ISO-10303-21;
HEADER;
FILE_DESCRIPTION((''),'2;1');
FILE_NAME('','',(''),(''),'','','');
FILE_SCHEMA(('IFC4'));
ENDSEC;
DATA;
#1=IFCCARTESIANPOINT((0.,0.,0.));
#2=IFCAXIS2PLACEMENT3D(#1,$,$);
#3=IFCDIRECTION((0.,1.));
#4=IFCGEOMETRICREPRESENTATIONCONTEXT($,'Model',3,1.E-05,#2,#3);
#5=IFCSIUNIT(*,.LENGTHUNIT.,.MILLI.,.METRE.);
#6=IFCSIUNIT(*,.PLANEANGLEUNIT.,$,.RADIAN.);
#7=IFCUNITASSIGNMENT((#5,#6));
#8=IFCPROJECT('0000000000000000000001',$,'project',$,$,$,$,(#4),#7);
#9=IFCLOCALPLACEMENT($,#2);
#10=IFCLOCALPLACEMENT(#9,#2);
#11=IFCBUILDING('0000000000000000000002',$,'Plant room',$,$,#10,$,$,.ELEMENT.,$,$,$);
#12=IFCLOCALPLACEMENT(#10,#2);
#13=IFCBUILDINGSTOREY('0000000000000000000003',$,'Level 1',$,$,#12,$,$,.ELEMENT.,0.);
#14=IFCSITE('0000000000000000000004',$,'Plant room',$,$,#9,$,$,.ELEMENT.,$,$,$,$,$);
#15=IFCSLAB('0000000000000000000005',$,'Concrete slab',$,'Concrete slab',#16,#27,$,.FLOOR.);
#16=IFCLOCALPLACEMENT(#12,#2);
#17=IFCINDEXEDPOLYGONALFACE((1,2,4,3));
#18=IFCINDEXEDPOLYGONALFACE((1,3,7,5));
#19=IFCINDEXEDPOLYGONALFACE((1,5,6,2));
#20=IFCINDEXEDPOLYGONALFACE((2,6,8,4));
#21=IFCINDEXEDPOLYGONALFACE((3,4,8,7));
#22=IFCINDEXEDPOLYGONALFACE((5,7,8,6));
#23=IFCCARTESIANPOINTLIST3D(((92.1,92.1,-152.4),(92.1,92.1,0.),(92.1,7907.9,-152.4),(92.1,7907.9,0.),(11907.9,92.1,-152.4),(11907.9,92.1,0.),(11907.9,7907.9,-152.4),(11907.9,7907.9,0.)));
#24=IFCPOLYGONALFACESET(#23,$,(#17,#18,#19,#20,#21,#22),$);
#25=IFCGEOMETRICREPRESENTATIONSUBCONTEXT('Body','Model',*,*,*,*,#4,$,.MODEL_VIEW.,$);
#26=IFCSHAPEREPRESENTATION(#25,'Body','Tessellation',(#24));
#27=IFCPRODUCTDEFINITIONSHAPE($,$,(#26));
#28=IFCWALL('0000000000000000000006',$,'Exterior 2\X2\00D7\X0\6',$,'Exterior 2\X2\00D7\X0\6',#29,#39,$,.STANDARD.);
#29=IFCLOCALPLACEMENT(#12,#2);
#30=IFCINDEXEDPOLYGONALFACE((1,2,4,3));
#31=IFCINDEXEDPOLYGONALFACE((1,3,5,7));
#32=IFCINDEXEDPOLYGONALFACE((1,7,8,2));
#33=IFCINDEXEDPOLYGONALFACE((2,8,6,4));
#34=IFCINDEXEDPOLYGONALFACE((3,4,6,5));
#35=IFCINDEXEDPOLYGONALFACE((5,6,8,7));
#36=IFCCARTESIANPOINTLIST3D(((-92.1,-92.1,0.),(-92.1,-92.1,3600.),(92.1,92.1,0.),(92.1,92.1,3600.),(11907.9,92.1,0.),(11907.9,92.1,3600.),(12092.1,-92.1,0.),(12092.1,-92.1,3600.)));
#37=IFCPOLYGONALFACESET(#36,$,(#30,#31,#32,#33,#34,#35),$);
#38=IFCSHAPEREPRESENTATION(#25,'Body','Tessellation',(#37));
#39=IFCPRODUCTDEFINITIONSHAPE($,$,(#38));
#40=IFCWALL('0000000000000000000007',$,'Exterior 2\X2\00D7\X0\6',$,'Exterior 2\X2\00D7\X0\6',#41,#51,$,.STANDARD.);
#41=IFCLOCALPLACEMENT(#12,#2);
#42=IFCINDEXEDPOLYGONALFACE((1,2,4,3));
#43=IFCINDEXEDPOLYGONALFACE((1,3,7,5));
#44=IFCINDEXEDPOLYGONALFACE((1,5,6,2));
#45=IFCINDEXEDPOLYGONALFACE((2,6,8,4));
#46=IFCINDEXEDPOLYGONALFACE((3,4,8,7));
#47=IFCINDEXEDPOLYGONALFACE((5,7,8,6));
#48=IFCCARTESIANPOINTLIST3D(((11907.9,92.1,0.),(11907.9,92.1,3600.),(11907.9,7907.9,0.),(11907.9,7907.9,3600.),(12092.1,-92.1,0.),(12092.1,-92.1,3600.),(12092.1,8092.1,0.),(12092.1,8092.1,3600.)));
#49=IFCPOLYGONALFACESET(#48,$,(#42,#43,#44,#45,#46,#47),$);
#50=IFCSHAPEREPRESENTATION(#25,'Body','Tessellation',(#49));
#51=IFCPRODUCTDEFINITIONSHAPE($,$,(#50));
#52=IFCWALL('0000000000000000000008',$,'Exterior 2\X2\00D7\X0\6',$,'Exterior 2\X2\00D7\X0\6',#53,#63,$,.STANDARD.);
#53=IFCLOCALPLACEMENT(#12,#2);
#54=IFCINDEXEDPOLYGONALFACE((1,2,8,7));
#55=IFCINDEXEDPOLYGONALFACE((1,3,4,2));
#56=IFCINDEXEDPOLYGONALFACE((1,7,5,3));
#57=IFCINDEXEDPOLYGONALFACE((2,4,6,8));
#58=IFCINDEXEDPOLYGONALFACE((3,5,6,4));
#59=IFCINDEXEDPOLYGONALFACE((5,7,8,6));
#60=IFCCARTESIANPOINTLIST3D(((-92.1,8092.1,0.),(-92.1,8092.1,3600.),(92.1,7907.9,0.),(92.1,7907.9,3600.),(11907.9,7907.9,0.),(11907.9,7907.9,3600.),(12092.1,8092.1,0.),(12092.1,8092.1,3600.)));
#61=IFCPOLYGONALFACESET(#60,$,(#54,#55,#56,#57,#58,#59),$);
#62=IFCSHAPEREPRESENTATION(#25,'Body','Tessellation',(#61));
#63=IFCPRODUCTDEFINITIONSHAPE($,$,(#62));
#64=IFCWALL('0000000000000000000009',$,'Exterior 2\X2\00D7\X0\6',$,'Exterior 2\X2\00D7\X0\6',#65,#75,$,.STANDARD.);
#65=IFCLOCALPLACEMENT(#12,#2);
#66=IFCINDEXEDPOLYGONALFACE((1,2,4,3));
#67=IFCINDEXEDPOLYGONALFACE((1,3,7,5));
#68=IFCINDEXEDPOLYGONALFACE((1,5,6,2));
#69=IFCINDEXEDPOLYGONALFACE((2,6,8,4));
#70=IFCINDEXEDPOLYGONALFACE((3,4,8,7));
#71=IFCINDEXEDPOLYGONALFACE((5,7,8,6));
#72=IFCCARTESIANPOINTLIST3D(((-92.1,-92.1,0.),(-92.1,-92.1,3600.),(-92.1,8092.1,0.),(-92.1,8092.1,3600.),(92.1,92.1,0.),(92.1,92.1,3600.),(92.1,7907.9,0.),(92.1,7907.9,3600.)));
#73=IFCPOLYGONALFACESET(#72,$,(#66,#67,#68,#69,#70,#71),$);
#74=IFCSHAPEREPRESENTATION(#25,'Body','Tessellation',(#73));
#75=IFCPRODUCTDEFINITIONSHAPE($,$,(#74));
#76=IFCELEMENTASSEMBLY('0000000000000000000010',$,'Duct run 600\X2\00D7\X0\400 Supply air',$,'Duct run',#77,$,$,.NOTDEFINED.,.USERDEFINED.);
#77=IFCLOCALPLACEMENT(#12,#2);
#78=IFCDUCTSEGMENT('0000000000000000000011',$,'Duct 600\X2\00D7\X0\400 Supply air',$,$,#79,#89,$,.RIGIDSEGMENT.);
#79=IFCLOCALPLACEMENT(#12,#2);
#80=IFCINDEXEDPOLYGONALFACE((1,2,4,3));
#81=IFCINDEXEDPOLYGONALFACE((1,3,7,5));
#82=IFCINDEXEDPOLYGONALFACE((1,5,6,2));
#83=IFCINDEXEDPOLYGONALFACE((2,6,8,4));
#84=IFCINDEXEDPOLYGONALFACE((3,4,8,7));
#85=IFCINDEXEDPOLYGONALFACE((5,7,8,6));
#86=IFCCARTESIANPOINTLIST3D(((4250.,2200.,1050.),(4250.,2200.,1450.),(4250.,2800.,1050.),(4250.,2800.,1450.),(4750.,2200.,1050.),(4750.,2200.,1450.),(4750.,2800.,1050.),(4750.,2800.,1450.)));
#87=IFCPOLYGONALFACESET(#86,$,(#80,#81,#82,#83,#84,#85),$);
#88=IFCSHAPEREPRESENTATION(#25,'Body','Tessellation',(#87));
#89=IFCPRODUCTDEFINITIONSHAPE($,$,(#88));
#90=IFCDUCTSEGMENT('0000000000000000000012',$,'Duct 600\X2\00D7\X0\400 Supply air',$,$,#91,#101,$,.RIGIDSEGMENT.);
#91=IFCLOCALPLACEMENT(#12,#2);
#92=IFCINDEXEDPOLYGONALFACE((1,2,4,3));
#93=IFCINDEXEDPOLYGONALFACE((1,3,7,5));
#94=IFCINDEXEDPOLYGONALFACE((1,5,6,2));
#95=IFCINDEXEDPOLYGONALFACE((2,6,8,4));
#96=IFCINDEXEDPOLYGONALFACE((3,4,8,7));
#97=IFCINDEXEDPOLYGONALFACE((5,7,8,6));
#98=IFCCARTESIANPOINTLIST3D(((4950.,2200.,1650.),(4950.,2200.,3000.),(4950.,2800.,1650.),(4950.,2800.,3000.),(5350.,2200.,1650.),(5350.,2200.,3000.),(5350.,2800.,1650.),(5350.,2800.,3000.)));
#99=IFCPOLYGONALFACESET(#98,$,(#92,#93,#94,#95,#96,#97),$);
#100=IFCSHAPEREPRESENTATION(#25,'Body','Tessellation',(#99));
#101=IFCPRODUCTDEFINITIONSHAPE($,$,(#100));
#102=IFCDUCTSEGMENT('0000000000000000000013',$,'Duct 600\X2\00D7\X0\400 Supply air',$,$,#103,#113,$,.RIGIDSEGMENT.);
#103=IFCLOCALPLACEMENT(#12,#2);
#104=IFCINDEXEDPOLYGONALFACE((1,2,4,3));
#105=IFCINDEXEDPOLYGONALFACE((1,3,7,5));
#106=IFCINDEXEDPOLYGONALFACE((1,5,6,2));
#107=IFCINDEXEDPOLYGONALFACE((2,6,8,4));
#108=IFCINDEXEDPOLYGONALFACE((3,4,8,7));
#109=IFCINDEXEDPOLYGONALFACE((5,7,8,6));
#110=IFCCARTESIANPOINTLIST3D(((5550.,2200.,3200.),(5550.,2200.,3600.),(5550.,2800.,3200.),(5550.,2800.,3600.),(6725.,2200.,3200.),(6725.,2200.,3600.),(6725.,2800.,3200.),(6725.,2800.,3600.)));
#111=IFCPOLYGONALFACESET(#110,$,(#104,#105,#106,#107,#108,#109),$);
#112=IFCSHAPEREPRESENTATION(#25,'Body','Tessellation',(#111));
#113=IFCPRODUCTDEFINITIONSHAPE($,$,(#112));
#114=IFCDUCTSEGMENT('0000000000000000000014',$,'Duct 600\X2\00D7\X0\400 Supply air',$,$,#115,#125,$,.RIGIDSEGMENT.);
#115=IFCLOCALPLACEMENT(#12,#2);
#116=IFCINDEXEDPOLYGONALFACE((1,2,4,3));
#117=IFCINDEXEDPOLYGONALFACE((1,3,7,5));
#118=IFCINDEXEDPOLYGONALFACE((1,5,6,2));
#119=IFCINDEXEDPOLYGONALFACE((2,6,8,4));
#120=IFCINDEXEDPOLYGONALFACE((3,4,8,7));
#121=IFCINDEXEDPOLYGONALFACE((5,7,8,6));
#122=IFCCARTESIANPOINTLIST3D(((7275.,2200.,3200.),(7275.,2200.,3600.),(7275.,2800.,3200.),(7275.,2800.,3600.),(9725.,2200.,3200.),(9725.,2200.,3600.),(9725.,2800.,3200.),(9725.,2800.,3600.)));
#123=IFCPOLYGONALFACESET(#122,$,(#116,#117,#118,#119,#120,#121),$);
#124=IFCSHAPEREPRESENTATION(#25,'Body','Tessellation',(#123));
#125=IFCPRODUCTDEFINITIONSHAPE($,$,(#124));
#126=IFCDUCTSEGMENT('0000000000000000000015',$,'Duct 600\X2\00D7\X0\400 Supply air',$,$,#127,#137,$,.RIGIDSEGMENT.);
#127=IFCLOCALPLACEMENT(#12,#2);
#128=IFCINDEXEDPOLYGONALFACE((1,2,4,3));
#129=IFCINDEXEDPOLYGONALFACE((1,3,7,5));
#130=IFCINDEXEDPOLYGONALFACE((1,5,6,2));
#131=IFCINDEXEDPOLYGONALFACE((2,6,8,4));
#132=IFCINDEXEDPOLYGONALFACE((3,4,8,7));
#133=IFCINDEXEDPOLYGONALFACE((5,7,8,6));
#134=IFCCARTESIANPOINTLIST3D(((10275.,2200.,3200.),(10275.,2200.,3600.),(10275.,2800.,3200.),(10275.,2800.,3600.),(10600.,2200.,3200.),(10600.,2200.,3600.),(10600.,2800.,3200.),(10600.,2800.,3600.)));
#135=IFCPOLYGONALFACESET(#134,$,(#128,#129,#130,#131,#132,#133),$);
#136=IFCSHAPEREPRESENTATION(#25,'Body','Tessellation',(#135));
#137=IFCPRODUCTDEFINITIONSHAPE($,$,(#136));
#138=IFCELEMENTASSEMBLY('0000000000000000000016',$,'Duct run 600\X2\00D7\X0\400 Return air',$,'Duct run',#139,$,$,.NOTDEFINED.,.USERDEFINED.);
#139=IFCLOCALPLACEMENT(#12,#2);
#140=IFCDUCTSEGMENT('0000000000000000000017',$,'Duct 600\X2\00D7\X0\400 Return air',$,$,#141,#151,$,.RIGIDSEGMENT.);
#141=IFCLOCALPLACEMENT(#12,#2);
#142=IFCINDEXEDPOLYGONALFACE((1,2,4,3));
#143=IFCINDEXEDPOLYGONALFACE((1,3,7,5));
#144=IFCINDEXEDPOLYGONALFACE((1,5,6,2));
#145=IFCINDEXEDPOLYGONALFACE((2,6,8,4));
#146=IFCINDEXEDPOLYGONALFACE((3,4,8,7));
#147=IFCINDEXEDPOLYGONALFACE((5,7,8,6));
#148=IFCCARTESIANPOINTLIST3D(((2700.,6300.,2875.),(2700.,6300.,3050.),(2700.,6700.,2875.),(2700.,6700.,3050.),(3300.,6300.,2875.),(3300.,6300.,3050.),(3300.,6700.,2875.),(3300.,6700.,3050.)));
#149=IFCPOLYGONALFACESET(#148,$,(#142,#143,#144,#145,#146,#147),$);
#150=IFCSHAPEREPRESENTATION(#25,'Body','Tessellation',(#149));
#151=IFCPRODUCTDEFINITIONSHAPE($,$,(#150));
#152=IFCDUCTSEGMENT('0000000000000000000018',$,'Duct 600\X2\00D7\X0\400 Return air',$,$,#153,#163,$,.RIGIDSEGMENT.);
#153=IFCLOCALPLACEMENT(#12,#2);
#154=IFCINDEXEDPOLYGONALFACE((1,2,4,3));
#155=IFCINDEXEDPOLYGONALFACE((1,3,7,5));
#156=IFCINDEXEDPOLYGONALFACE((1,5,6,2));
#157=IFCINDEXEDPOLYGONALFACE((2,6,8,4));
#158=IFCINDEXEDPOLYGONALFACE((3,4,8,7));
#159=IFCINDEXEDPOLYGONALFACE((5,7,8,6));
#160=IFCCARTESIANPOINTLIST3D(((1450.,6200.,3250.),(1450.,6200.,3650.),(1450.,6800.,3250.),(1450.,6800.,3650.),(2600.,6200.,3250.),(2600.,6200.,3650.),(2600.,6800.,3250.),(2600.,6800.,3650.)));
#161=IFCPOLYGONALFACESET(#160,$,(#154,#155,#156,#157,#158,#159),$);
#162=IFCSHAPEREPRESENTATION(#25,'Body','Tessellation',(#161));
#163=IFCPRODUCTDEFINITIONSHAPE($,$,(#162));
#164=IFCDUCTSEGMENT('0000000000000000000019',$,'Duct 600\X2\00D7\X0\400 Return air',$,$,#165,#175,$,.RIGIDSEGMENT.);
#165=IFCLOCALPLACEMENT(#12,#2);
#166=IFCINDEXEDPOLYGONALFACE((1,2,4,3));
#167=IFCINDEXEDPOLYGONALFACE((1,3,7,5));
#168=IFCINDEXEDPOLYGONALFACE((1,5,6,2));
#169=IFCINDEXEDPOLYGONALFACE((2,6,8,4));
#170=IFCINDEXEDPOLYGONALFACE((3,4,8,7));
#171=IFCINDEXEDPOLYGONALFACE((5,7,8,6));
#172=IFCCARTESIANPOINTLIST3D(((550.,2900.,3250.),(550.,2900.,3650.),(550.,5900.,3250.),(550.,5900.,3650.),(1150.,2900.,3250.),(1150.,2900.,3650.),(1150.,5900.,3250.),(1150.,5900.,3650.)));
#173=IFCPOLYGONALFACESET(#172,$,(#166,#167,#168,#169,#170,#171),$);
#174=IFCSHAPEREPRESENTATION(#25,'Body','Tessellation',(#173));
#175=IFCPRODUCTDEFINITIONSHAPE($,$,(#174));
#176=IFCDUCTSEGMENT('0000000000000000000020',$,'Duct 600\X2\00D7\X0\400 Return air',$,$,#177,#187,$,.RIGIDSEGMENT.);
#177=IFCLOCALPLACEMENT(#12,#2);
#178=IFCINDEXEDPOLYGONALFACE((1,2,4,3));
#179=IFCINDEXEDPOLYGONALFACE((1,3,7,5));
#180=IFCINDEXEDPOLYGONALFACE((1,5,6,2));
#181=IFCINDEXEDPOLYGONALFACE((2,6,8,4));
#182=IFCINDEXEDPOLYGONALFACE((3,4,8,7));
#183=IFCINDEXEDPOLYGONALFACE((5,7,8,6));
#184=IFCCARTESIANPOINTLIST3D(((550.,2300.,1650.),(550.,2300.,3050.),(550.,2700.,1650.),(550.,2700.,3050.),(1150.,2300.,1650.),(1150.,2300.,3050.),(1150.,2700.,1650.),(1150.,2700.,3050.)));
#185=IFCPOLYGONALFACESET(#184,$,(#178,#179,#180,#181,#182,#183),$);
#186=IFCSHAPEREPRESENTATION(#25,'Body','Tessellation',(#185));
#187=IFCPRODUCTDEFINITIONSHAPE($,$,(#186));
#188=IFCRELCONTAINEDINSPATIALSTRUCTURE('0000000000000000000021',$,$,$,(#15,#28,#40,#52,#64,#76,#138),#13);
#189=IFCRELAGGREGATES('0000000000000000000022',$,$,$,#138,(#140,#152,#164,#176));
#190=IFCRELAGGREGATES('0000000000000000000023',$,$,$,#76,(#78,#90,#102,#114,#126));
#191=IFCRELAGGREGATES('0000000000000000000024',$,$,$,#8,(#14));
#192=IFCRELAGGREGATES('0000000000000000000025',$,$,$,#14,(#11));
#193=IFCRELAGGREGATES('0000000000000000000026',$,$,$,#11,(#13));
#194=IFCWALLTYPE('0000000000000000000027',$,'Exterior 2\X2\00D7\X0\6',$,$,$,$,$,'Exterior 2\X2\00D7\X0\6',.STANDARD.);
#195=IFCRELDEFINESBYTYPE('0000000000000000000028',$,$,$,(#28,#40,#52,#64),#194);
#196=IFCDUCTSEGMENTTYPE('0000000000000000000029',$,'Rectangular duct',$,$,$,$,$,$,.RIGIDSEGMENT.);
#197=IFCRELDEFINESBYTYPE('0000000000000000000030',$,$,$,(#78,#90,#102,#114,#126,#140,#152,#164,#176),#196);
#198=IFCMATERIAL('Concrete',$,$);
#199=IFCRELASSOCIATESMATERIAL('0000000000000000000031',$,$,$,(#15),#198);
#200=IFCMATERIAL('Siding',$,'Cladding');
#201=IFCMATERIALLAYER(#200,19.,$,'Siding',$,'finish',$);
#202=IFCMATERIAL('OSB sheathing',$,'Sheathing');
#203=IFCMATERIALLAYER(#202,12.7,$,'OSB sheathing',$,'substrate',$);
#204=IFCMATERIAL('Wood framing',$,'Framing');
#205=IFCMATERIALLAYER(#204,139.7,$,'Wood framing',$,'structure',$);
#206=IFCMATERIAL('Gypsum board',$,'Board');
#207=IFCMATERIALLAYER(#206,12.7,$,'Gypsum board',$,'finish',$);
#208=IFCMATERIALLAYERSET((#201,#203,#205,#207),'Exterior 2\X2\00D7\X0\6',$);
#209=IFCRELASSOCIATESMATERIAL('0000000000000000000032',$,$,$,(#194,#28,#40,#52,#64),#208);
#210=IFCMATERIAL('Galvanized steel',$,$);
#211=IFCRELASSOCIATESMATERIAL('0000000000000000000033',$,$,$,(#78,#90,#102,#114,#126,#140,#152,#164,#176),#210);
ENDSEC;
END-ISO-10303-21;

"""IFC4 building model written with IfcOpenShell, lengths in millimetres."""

from ifc_helpers import new_model, si_unit, direction, frame, origin, origin_with_axes, origin_2d, place, context, subcontext, project, spatial, polyline, rectangle, outline, extrude, material, layer, layer_set, layer_usage, type_object, element, aggregate, save


model = new_model("IFC4")

# Units and contexts
model_context = context("Model", 3, precision=1e-05, world=origin(), true_north=direction((0.0, 1.0)))
body_context = subcontext(model_context, "Body", "Model", "MODEL_VIEW")
ifc_project = project(units=[si_unit("LENGTHUNIT", "METRE", prefix="MILLI"), si_unit("PLANEANGLEUNIT", "RADIAN")], contexts=[model_context])

# Site, building, storey
site_placement = place(None, origin())
site = spatial("IfcSite", under=ifc_project, at=site_placement, Name="Plant room", CompositionType="ELEMENT")
building_placement = place(site_placement, origin())
building = spatial("IfcBuilding", under=site, at=building_placement, Name="Plant room", CompositionType="ELEMENT")
storey_placement = place(building_placement, origin())
storey = spatial("IfcBuildingStorey", under=building, at=storey_placement, Name="Level 1", CompositionType="ELEMENT", Elevation=0.0)

# Slab
ifc_material_1 = material(Name="Concrete")
slab_placement = place(storey_placement, origin_with_axes())
element("IfcSlab", 1, at=slab_placement, inside=storey, material=ifc_material_1, Name="Concrete slab", ObjectType="Concrete slab", PredefinedType="FLOOR", context=body_context, shape_type="SweptSolid", body=[
    extrude(outline(polyline([(92.1, 92.1), (11907.9, 92.1), (11907.9, 7907.9), (92.1, 7907.9), (92.1, 92.1)])), frame((0.0, 0.0, -152.4)), (0.0, 0.0, 1.0), 152.4),
])

# Walls
ifc_material_2 = material(Name="Siding", Category="Cladding")
ifc_layer_1 = layer(ifc_material_2, 19.0, Name="Siding", Category="finish")
ifc_material_3 = material(Name="OSB sheathing", Category="Sheathing")
ifc_layer_2 = layer(ifc_material_3, 12.7, Name="OSB sheathing", Category="substrate")
ifc_material_4 = material(Name="Wood framing", Category="Framing")
ifc_layer_3 = layer(ifc_material_4, 139.7, Name="Wood framing", Category="structure")
ifc_material_5 = material(Name="Gypsum board", Category="Board")
ifc_layer_4 = layer(ifc_material_5, 12.7, Name="Gypsum board", Category="finish")
ifc_layer_set = layer_set([ifc_layer_1, ifc_layer_2, ifc_layer_3, ifc_layer_4], Name="Exterior 2×6")
ifc_layer_usage_1 = layer_usage(ifc_layer_set, "AXIS2", "NEGATIVE", 92.1)
wall_type = type_object("IfcWallType", Name="Exterior 2×6", ElementType="Exterior 2×6", PredefinedType="STANDARD", material=ifc_layer_set)
wall_1_placement = place(storey_placement, origin_with_axes())
element("IfcWall", 2, at=wall_1_placement, inside=storey, type_object=wall_type, material=ifc_layer_usage_1, Name="Exterior 2×6", ObjectType="Exterior 2×6", PredefinedType="STANDARD", context=body_context, shape_type="SweptSolid", body=[
    extrude(outline(polyline([(-92.1, -92.1), (12092.1, -92.1), (11907.9, 92.1), (92.1, 92.1), (-92.1, -92.1)])), origin(), (0.0, 0.0, 1.0), 3600.0),
])
ifc_layer_usage_2 = layer_usage(ifc_layer_set, "AXIS2", "NEGATIVE", 92.1)
wall_2_placement = place(storey_placement, frame((12000.0, 0.0, 0.0), z_axis=(0.0, 0.0, 1.0), x_axis=(0.0, 1.0, 0.0)))
element("IfcWall", 3, at=wall_2_placement, inside=storey, type_object=wall_type, material=ifc_layer_usage_2, Name="Exterior 2×6", ObjectType="Exterior 2×6", PredefinedType="STANDARD", context=body_context, shape_type="SweptSolid", body=[
    extrude(outline(polyline([(-92.1, -92.1), (8092.1, -92.1), (7907.9, 92.1), (92.1, 92.1), (-92.1, -92.1)])), origin(), (0.0, 0.0, 1.0), 3600.0),
])
ifc_layer_usage_3 = layer_usage(ifc_layer_set, "AXIS2", "NEGATIVE", 92.1)
wall_3_placement = place(storey_placement, frame((12000.0, 8000.0, 0.0), z_axis=(0.0, 0.0, 1.0), x_axis=(-1.0, 0.0, 0.0)))
element("IfcWall", 4, at=wall_3_placement, inside=storey, type_object=wall_type, material=ifc_layer_usage_3, Name="Exterior 2×6", ObjectType="Exterior 2×6", PredefinedType="STANDARD", context=body_context, shape_type="SweptSolid", body=[
    extrude(outline(polyline([(-92.1, -92.1), (12092.1, -92.1), (11907.9, 92.1), (92.1, 92.1), (-92.1, -92.1)])), origin(), (0.0, 0.0, 1.0), 3600.0),
])
ifc_layer_usage_4 = layer_usage(ifc_layer_set, "AXIS2", "NEGATIVE", 92.1)
wall_4_placement = place(storey_placement, frame((0.0, 8000.0, 0.0), z_axis=(0.0, 0.0, 1.0), x_axis=(0.0, -1.0, 0.0)))
element("IfcWall", 5, at=wall_4_placement, inside=storey, type_object=wall_type, material=ifc_layer_usage_4, Name="Exterior 2×6", ObjectType="Exterior 2×6", PredefinedType="STANDARD", context=body_context, shape_type="SweptSolid", body=[
    extrude(outline(polyline([(-92.1, -92.1), (8092.1, -92.1), (7907.9, 92.1), (92.1, 92.1), (-92.1, -92.1)])), origin(), (0.0, 0.0, 1.0), 3600.0),
])

# Element assemblies, duct segments
assembly_1_placement = place(storey_placement, origin_with_axes())
assembly_1 = element("IfcElementAssembly", 6, at=assembly_1_placement, inside=storey, Name="Duct run 600×400 Supply air", ObjectType="Duct run", AssemblyPlace="NOTDEFINED", PredefinedType="USERDEFINED")
ifc_material_6 = material(Name="Galvanized steel")
duct_segment_type_1 = type_object("IfcDuctSegmentType", Name="Rectangular duct", PredefinedType="RIGIDSEGMENT")
duct_segment_1_placement = place(storey_placement, origin_with_axes())
duct_segment_1 = element("IfcDuctSegment", 7, at=duct_segment_1_placement, type_object=duct_segment_type_1, material=ifc_material_6, Name="Duct 600×400 Supply air", PredefinedType="RIGIDSEGMENT", context=body_context, shape_type="SweptSolid", body=[
    extrude(rectangle(XDim=600.0, YDim=400.0, at=origin_2d()), frame((4250.0, 2500.0, 1250.0), z_axis=(1.0, 0.0, 0.0), x_axis=(0.0, 1.0, 0.0)), (0.0, 0.0, 1.0), 500.0),
])
duct_segment_2_placement = place(storey_placement, origin_with_axes())
duct_segment_2 = element("IfcDuctSegment", 8, at=duct_segment_2_placement, type_object=duct_segment_type_1, material=ifc_material_6, Name="Duct 600×400 Supply air", PredefinedType="RIGIDSEGMENT", context=body_context, shape_type="SweptSolid", body=[
    extrude(rectangle(XDim=600.0, YDim=400.0, at=origin_2d()), frame((5150.0, 2500.0, 1650.0), z_axis=(0.0, 0.0, 1.0), x_axis=(0.0, 1.0, 0.0)), (0.0, 0.0, 1.0), 1350.0),
])
duct_segment_3_placement = place(storey_placement, origin_with_axes())
duct_segment_3 = element("IfcDuctSegment", 9, at=duct_segment_3_placement, type_object=duct_segment_type_1, material=ifc_material_6, Name="Duct 600×400 Supply air", PredefinedType="RIGIDSEGMENT", context=body_context, shape_type="SweptSolid", body=[
    extrude(rectangle(XDim=600.0, YDim=400.0, at=origin_2d()), frame((5550.0, 2500.0, 3400.0), z_axis=(1.0, 0.0, 0.0), x_axis=(0.0, 1.0, 0.0)), (0.0, 0.0, 1.0), 1175.0),
])
duct_segment_4_placement = place(storey_placement, origin_with_axes())
duct_segment_4 = element("IfcDuctSegment", 10, at=duct_segment_4_placement, type_object=duct_segment_type_1, material=ifc_material_6, Name="Duct 600×400 Supply air", PredefinedType="RIGIDSEGMENT", context=body_context, shape_type="SweptSolid", body=[
    extrude(rectangle(XDim=600.0, YDim=400.0, at=origin_2d()), frame((7275.0, 2500.0, 3400.0), z_axis=(1.0, 0.0, 0.0), x_axis=(0.0, 1.0, 0.0)), (0.0, 0.0, 1.0), 2450.0),
])
duct_segment_5_placement = place(storey_placement, origin_with_axes())
duct_segment_5 = element("IfcDuctSegment", 11, at=duct_segment_5_placement, type_object=duct_segment_type_1, material=ifc_material_6, Name="Duct 600×400 Supply air", PredefinedType="RIGIDSEGMENT", context=body_context, shape_type="SweptSolid", body=[
    extrude(rectangle(XDim=600.0, YDim=400.0, at=origin_2d()), frame((10275.0, 2500.0, 3400.0), z_axis=(1.0, 0.0, 0.0), x_axis=(0.0, 1.0, 0.0)), (0.0, 0.0, 1.0), 325.0),
])
assembly_2_placement = place(storey_placement, origin_with_axes())
assembly_2 = element("IfcElementAssembly", 12, at=assembly_2_placement, inside=storey, Name="Duct run 600×400 Return air", ObjectType="Duct run", AssemblyPlace="NOTDEFINED", PredefinedType="USERDEFINED")
duct_segment_6_placement = place(storey_placement, origin_with_axes())
duct_segment_6 = element("IfcDuctSegment", 13, at=duct_segment_6_placement, type_object=duct_segment_type_1, material=ifc_material_6, Name="Duct 600×400 Return air", PredefinedType="RIGIDSEGMENT", context=body_context, shape_type="SweptSolid", body=[
    extrude(rectangle(XDim=600.0, YDim=400.0, at=origin_2d()), frame((3000.0, 6500.0, 2875.0), z_axis=(0.0, 0.0, 1.0), x_axis=(1.0, 0.0, 0.0)), (0.0, 0.0, 1.0), 175.0),
])
duct_segment_7_placement = place(storey_placement, origin_with_axes())
duct_segment_7 = element("IfcDuctSegment", 14, at=duct_segment_7_placement, type_object=duct_segment_type_1, material=ifc_material_6, Name="Duct 600×400 Return air", PredefinedType="RIGIDSEGMENT", context=body_context, shape_type="SweptSolid", body=[
    extrude(rectangle(XDim=600.0, YDim=400.0, at=origin_2d()), frame((2600.0, 6500.0, 3450.0), z_axis=(-1.0, 0.0, 0.0), x_axis=(0.0, -1.0, 0.0)), (0.0, 0.0, 1.0), 1150.0),
])
duct_segment_8_placement = place(storey_placement, origin_with_axes())
duct_segment_8 = element("IfcDuctSegment", 15, at=duct_segment_8_placement, type_object=duct_segment_type_1, material=ifc_material_6, Name="Duct 600×400 Return air", PredefinedType="RIGIDSEGMENT", context=body_context, shape_type="SweptSolid", body=[
    extrude(rectangle(XDim=600.0, YDim=400.0, at=origin_2d()), frame((850.0, 5900.0, 3450.0), z_axis=(0.0, -1.0, 0.0), x_axis=(1.0, 0.0, 0.0)), (0.0, 0.0, 1.0), 3000.0),
])
duct_segment_9_placement = place(storey_placement, origin_with_axes())
duct_segment_9 = element("IfcDuctSegment", 16, at=duct_segment_9_placement, type_object=duct_segment_type_1, material=ifc_material_6, Name="Duct 600×400 Return air", PredefinedType="RIGIDSEGMENT", context=body_context, shape_type="SweptSolid", body=[
    extrude(rectangle(XDim=600.0, YDim=400.0, at=origin_2d()), frame((850.0, 2500.0, 3050.0), z_axis=(0.0, 0.0, -1.0), x_axis=(1.0, 0.0, 0.0)), (0.0, 0.0, 1.0), 1400.0),
])

aggregate(assembly_2, [duct_segment_6, duct_segment_7, duct_segment_8, duct_segment_9])
aggregate(assembly_1, [duct_segment_1, duct_segment_2, duct_segment_3, duct_segment_4, duct_segment_5])

save(model, "model.ifc")
